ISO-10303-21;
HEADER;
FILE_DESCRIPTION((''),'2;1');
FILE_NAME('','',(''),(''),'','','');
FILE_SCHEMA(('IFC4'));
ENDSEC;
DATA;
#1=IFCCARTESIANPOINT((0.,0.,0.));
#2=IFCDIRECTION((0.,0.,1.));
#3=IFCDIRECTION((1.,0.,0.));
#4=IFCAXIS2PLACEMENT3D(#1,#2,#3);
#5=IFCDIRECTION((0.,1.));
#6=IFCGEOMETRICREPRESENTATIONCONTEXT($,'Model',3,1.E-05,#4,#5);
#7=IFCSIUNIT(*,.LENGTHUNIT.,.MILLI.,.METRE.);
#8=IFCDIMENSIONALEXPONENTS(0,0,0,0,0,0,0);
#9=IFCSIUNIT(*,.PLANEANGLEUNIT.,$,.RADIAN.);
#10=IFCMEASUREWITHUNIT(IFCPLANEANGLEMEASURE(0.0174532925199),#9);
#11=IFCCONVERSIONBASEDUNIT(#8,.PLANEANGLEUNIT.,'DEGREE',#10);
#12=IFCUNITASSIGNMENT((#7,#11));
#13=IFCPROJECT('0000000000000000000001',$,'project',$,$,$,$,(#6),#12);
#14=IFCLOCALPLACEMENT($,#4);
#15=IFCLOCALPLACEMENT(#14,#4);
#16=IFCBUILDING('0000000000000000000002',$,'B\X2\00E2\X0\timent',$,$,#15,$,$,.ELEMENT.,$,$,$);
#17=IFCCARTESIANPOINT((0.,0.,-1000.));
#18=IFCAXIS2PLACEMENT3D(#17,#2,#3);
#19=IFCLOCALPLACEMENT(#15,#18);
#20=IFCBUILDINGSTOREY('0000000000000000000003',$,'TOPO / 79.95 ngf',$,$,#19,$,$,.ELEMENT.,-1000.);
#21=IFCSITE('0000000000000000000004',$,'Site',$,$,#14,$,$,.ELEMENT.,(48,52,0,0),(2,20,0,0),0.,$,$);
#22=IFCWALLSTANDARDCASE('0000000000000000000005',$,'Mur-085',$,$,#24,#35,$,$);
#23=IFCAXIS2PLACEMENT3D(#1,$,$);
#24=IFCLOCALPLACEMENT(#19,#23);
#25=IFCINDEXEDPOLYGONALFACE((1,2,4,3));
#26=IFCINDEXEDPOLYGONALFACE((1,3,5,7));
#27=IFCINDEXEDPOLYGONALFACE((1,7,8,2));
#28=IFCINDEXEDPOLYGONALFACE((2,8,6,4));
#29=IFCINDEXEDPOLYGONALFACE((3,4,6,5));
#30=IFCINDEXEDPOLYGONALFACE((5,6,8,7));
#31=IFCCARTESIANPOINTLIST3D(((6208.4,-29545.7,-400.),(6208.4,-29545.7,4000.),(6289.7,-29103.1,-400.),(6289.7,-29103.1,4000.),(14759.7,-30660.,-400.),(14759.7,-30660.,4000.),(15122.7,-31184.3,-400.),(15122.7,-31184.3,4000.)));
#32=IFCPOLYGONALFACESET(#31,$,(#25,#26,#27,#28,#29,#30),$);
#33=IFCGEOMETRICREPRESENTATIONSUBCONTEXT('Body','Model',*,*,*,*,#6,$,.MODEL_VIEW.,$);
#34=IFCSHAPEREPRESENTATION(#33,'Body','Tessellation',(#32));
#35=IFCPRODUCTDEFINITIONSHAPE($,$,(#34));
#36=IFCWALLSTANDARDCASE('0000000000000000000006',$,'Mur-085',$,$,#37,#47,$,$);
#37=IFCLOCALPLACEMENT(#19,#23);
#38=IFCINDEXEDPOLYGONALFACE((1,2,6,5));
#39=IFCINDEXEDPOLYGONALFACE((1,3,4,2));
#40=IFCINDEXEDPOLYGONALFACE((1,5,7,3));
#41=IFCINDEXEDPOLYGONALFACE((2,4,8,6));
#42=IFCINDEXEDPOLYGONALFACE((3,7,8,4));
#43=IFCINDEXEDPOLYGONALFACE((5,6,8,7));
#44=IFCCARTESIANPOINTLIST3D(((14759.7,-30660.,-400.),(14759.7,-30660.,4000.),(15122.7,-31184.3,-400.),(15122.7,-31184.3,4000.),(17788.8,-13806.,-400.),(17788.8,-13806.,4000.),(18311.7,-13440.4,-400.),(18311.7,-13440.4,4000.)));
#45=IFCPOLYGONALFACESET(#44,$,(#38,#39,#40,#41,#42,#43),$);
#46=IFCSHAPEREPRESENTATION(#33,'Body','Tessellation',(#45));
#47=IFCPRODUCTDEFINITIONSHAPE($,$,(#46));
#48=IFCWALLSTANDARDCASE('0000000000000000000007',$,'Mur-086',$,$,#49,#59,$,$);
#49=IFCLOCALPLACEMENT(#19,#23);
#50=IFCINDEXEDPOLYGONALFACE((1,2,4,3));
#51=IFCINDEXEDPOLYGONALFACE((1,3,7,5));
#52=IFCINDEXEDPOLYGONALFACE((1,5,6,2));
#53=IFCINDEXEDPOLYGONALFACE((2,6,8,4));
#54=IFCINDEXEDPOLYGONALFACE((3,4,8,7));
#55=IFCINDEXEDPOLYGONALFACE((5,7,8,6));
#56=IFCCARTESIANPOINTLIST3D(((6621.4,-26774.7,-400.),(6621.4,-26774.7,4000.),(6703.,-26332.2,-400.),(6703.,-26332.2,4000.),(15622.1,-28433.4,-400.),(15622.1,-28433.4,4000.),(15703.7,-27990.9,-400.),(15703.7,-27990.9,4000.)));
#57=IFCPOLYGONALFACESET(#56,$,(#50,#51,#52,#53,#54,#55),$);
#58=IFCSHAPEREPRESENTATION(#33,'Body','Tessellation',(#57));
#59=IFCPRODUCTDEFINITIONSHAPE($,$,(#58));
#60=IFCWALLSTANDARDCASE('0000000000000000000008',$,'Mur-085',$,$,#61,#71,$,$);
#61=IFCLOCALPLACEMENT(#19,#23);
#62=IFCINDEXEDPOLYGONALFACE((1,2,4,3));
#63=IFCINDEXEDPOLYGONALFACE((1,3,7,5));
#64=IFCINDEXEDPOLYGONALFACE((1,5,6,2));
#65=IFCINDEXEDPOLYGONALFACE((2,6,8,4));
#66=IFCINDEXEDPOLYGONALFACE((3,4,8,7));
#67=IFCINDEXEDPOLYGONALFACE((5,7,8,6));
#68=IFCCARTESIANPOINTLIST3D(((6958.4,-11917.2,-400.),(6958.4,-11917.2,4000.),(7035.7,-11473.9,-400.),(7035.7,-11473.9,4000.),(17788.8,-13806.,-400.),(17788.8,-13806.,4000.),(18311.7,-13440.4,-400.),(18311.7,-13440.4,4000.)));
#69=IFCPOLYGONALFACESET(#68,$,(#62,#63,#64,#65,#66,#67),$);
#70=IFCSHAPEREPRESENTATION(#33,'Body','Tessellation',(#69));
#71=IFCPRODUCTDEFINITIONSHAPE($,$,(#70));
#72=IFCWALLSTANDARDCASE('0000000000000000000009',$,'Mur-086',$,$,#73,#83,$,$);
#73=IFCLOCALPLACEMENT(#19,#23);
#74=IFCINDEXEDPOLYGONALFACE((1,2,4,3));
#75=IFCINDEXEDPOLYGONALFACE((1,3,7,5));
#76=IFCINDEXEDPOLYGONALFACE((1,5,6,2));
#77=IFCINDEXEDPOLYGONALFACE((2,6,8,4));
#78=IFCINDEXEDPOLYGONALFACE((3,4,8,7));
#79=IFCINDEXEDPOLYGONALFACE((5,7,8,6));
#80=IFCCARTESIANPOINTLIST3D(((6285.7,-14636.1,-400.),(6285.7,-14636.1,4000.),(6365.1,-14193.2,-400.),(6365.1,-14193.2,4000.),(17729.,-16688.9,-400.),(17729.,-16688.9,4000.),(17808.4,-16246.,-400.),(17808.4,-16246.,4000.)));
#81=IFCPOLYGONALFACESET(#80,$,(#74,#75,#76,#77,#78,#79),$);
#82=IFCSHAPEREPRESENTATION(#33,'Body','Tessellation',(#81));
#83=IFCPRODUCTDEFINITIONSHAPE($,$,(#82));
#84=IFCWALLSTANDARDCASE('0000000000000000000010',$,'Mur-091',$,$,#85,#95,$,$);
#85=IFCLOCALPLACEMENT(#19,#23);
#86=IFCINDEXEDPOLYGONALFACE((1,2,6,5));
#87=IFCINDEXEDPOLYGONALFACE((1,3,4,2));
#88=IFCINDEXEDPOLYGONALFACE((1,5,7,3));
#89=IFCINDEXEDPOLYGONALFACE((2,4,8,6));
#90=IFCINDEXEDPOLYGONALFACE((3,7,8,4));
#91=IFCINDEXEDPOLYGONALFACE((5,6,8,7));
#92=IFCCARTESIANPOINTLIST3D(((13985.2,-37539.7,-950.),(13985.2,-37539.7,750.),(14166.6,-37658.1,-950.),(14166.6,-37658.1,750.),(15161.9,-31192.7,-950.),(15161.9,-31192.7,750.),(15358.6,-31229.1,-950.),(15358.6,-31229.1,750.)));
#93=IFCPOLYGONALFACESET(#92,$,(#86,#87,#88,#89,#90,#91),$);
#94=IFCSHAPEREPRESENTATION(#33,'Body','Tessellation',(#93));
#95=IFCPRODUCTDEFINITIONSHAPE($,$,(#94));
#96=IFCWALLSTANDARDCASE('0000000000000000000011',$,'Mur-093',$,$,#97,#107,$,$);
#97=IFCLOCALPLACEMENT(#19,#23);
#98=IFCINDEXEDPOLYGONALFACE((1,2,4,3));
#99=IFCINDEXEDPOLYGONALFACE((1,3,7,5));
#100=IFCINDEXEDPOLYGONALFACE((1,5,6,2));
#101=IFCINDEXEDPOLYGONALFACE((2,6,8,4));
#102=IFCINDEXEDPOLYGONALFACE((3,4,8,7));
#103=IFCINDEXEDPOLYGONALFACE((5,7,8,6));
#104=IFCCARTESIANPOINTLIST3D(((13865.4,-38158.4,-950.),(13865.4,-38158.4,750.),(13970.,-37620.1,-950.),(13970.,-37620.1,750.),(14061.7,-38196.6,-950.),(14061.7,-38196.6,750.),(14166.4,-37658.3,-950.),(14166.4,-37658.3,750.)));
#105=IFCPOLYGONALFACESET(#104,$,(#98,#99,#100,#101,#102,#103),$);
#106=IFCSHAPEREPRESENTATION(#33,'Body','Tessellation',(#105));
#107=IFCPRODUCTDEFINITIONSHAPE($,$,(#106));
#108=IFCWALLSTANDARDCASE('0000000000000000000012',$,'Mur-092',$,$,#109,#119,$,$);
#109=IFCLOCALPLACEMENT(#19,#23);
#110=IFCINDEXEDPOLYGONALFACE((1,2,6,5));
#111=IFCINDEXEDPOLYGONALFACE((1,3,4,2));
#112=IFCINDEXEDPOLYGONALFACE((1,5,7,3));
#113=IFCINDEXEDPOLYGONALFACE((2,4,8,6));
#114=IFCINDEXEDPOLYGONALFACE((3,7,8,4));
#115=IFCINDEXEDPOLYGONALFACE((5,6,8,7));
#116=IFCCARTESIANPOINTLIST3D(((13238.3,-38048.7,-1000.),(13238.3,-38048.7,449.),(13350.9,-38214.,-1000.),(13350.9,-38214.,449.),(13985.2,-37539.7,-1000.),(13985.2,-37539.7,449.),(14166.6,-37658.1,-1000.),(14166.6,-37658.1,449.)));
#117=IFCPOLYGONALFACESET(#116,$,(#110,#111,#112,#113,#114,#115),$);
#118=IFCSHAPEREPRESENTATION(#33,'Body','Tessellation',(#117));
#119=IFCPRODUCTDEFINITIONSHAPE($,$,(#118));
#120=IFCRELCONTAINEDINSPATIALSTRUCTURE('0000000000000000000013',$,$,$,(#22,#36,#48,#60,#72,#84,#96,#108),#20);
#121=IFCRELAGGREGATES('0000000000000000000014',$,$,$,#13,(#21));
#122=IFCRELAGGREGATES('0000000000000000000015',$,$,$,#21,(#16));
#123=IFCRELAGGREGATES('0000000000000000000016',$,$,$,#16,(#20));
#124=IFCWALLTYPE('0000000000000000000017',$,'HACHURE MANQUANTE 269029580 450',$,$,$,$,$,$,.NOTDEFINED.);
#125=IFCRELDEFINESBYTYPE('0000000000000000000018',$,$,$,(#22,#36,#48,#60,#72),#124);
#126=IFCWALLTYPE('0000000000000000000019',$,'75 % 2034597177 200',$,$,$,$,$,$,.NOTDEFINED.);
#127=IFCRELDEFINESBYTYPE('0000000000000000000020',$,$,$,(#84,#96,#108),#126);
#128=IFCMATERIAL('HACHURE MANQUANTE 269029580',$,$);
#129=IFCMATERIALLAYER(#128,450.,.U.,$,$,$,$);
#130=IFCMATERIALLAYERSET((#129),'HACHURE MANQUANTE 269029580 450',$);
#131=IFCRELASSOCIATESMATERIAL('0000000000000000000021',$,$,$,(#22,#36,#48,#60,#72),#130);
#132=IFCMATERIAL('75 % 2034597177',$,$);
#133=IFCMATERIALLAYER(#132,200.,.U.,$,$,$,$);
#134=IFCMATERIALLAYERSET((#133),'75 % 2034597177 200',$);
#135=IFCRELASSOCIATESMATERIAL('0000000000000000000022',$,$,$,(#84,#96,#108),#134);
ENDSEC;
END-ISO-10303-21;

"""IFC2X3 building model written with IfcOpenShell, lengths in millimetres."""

from ifc_helpers import new_model, entity, si_unit, converted_unit, direction, frame, origin_with_axes, place, context, subcontext, project, spatial, polyline, outline, extrude, material, layer, layer_set, layer_usage, type_object, element, save


model = new_model("IFC2X3")

# Units and contexts
model_context = context("Model", 3, precision=1e-05, world=origin_with_axes(), true_north=direction((0.0, 1.0)))
body_context = subcontext(model_context, "Body", "Model", "MODEL_VIEW")
ifc_project = project(units=[si_unit("LENGTHUNIT", "METRE", prefix="MILLI"), converted_unit("PLANEANGLEUNIT", "DEGREE", entity("IfcPlaneAngleMeasure", 0.0174532925199), si_unit("PLANEANGLEUNIT", "RADIAN"), dimensions=[0, 0, 0, 0, 0, 0, 0])], contexts=[model_context])

# Site, building, storey
site_placement = place(None, origin_with_axes())
site = spatial("IfcSite", under=ifc_project, at=site_placement, Name="Site", CompositionType="ELEMENT", RefLatitude=(48, 52, 0, 0), RefLongitude=(2, 20, 0, 0), RefElevation=0.0)
building_placement = place(site_placement, origin_with_axes())
building = spatial("IfcBuilding", under=site, at=building_placement, Name="Bâtiment", CompositionType="ELEMENT")
storey_placement = place(building_placement, frame((0.0, 0.0, -1000.0), z_axis=(0.0, 0.0, 1.0), x_axis=(1.0, 0.0, 0.0)))
storey = spatial("IfcBuildingStorey", under=building, at=storey_placement, Name="TOPO / 79.95 ngf", CompositionType="ELEMENT", Elevation=-1000.0)

# Walls
ifc_material_1 = material(Name="75 % 2034597177")
ifc_material_2 = material(Name="HACHURE MANQUANTE 269029580")
ifc_layer_1 = layer(ifc_material_2, 450.0, ventilated="UNKNOWN")
ifc_layer_set_1 = layer_set([ifc_layer_1], Name="HACHURE MANQUANTE 269029580 450")
ifc_layer_usage_1 = layer_usage(ifc_layer_set_1, "AXIS2", "NEGATIVE", 450.0)
wall_type_1 = type_object("IfcWallType", Name="HACHURE MANQUANTE 269029580 450", PredefinedType="NOTDEFINED")
wall_1_placement = place(storey_placement, frame((6208.4, -29545.7, -400.0), z_axis=(0.0, 0.0, 1.0), x_axis=(0.983523, -0.18078, 0.0)))
element("IfcWallStandardCase", 1, at=wall_1_placement, inside=storey, type_object=wall_type_1, material=ifc_layer_usage_1, Name="Mur-085", context=body_context, shape_type="SweptSolid", body=[
    extrude(outline(polyline([(0.0, 0.0), (9063.7, 0.0), (8611.9, 450.0), (0.0, 450.0), (0.0, 0.0)])), origin_with_axes(), (0.0, 0.0, 1.0), 4400.0),
])
ifc_layer_usage_2 = layer_usage(ifc_layer_set_1, "AXIS2", "POSITIVE", -450.0)
wall_2_placement = place(storey_placement, frame((18311.7, -13440.4, -400.0), z_axis=(0.0, 0.0, 1.0), x_axis=(-0.176891, -0.98423, 0.0)))
element("IfcWallStandardCase", 2, at=wall_2_placement, inside=storey, type_object=wall_type_1, material=ifc_layer_usage_2, Name="Mur-085", context=body_context, shape_type="SweptSolid", body=[
    extrude(outline(polyline([(452.3, -450.0), (17576.4, -450.0), (18028.1, 0.0), (0.0, 0.0), (452.3, -450.0)])), origin_with_axes(), (0.0, 0.0, 1.0), 4400.0),
])
ifc_layer_usage_3 = layer_usage(ifc_layer_set_1, "AXIS2", "POSITIVE", -450.0)
wall_3_placement = place(storey_placement, frame((15622.1, -28433.4, -400.0), z_axis=(0.0, 0.0, 1.0), x_axis=(-0.98344, 0.181233, 0.0)))
element("IfcWallStandardCase", 3, at=wall_3_placement, inside=storey, type_object=wall_type_1, material=ifc_layer_usage_3, Name="Mur-086", context=body_context, shape_type="SweptSolid", body=[
    extrude(outline(polyline([(0.0, -450.0), (9152.3, -450.0), (9152.3, 0.0), (0.0, 0.0), (0.0, -450.0)])), origin_with_axes(), (0.0, 0.0, 1.0), 4400.0),
])
ifc_layer_usage_4 = layer_usage(ifc_layer_set_1, "AXIS2", "POSITIVE", -450.0)
wall_4_placement = place(storey_placement, frame((7035.7, -11473.9, -400.0), z_axis=(0.0, 0.0, 1.0), x_axis=(0.985131, -0.171804, 0.0)))
element("IfcWallStandardCase", 4, at=wall_4_placement, inside=storey, type_object=wall_type_1, material=ifc_layer_usage_4, Name="Mur-085", context=body_context, shape_type="SweptSolid", body=[
    extrude(outline(polyline([(0.0, -450.0), (10993.9, -450.0), (11446.2, 0.0), (0.0, 0.0), (0.0, -450.0)])), origin_with_axes(), (0.0, 0.0, 1.0), 4400.0),
])
ifc_layer_usage_5 = layer_usage(ifc_layer_set_1, "AXIS2", "NEGATIVE", 450.0)
wall_5_placement = place(storey_placement, frame((17808.4, -16246.0, -400.0), z_axis=(0.0, 0.0, 1.0), x_axis=(-0.984288, 0.17657, 0.0)))
element("IfcWallStandardCase", 5, at=wall_5_placement, inside=storey, type_object=wall_type_1, material=ifc_layer_usage_5, Name="Mur-086", context=body_context, shape_type="SweptSolid", body=[
    extrude(outline(polyline([(0.0, 0.0), (11626.0, 0.0), (11626.0, 450.0), (0.0, 450.0), (0.0, 0.0)])), origin_with_axes(), (0.0, 0.0, 1.0), 4400.0),
])
ifc_layer_2 = layer(ifc_material_1, 200.0, ventilated="UNKNOWN")
ifc_layer_set_2 = layer_set([ifc_layer_2], Name="75 % 2034597177 200")
ifc_layer_usage_6 = layer_usage(ifc_layer_set_2, "AXIS2", "NEGATIVE", 200.0)
wall_type_2 = type_object("IfcWallType", Name="75 % 2034597177 200", PredefinedType="NOTDEFINED")
wall_6_placement = place(storey_placement, frame((15161.9, -31192.7, -950.0), z_axis=(0.0, 0.0, 1.0), x_axis=(-0.182296, -0.983244, 0.0)))
element("IfcWallStandardCase", 6, at=wall_6_placement, inside=storey, type_object=wall_type_2, material=ifc_layer_usage_6, Name="Mur-091", context=body_context, shape_type="SweptSolid", body=[
    extrude(outline(polyline([(0.0, 0.0), (6455.2, 0.0), (6538.5, 200.0), (0.0, 200.0), (0.0, 0.0)])), origin_with_axes(), (0.0, 0.0, 1.0), 1700.0),
])
ifc_layer_usage_7 = layer_usage(ifc_layer_set_2, "AXIS2", "POSITIVE", -200.0)
wall_7_placement = place(storey_placement, frame((14166.4, -37658.3, -950.0), z_axis=(0.0, 0.0, 1.0), x_axis=(-0.190862, -0.981617, 0.0)))
element("IfcWallStandardCase", 7, at=wall_7_placement, inside=storey, type_object=wall_type_2, material=ifc_layer_usage_7, Name="Mur-093", context=body_context, shape_type="SweptSolid", body=[
    extrude(outline(polyline([(0.0, -200.0), (548.4, -200.0), (548.4, 0.0), (0.0, 0.0), (0.0, -200.0)])), origin_with_axes(), (0.0, 0.0, 1.0), 1700.0),
])
ifc_layer_usage_8 = layer_usage(ifc_layer_set_2, "AXIS2", "NEGATIVE", 200.0)
wall_8_placement = place(storey_placement, frame((13985.2, -37539.7, -1000.0), z_axis=(0.0, 0.0, 1.0), x_axis=(-0.826372, -0.563124, 0.0)))
element("IfcWallStandardCase", 8, at=wall_8_placement, inside=storey, type_object=wall_type_2, material=ifc_layer_usage_8, Name="Mur-092", context=body_context, shape_type="SweptSolid", body=[
    extrude(outline(polyline([(0.0, 0.0), (903.9, 0.0), (903.9, 200.0), (-83.3, 200.0), (0.0, 0.0)])), origin_with_axes(), (0.0, 0.0, 1.0), 1449.0),
])

save(model, "model.ifc")
